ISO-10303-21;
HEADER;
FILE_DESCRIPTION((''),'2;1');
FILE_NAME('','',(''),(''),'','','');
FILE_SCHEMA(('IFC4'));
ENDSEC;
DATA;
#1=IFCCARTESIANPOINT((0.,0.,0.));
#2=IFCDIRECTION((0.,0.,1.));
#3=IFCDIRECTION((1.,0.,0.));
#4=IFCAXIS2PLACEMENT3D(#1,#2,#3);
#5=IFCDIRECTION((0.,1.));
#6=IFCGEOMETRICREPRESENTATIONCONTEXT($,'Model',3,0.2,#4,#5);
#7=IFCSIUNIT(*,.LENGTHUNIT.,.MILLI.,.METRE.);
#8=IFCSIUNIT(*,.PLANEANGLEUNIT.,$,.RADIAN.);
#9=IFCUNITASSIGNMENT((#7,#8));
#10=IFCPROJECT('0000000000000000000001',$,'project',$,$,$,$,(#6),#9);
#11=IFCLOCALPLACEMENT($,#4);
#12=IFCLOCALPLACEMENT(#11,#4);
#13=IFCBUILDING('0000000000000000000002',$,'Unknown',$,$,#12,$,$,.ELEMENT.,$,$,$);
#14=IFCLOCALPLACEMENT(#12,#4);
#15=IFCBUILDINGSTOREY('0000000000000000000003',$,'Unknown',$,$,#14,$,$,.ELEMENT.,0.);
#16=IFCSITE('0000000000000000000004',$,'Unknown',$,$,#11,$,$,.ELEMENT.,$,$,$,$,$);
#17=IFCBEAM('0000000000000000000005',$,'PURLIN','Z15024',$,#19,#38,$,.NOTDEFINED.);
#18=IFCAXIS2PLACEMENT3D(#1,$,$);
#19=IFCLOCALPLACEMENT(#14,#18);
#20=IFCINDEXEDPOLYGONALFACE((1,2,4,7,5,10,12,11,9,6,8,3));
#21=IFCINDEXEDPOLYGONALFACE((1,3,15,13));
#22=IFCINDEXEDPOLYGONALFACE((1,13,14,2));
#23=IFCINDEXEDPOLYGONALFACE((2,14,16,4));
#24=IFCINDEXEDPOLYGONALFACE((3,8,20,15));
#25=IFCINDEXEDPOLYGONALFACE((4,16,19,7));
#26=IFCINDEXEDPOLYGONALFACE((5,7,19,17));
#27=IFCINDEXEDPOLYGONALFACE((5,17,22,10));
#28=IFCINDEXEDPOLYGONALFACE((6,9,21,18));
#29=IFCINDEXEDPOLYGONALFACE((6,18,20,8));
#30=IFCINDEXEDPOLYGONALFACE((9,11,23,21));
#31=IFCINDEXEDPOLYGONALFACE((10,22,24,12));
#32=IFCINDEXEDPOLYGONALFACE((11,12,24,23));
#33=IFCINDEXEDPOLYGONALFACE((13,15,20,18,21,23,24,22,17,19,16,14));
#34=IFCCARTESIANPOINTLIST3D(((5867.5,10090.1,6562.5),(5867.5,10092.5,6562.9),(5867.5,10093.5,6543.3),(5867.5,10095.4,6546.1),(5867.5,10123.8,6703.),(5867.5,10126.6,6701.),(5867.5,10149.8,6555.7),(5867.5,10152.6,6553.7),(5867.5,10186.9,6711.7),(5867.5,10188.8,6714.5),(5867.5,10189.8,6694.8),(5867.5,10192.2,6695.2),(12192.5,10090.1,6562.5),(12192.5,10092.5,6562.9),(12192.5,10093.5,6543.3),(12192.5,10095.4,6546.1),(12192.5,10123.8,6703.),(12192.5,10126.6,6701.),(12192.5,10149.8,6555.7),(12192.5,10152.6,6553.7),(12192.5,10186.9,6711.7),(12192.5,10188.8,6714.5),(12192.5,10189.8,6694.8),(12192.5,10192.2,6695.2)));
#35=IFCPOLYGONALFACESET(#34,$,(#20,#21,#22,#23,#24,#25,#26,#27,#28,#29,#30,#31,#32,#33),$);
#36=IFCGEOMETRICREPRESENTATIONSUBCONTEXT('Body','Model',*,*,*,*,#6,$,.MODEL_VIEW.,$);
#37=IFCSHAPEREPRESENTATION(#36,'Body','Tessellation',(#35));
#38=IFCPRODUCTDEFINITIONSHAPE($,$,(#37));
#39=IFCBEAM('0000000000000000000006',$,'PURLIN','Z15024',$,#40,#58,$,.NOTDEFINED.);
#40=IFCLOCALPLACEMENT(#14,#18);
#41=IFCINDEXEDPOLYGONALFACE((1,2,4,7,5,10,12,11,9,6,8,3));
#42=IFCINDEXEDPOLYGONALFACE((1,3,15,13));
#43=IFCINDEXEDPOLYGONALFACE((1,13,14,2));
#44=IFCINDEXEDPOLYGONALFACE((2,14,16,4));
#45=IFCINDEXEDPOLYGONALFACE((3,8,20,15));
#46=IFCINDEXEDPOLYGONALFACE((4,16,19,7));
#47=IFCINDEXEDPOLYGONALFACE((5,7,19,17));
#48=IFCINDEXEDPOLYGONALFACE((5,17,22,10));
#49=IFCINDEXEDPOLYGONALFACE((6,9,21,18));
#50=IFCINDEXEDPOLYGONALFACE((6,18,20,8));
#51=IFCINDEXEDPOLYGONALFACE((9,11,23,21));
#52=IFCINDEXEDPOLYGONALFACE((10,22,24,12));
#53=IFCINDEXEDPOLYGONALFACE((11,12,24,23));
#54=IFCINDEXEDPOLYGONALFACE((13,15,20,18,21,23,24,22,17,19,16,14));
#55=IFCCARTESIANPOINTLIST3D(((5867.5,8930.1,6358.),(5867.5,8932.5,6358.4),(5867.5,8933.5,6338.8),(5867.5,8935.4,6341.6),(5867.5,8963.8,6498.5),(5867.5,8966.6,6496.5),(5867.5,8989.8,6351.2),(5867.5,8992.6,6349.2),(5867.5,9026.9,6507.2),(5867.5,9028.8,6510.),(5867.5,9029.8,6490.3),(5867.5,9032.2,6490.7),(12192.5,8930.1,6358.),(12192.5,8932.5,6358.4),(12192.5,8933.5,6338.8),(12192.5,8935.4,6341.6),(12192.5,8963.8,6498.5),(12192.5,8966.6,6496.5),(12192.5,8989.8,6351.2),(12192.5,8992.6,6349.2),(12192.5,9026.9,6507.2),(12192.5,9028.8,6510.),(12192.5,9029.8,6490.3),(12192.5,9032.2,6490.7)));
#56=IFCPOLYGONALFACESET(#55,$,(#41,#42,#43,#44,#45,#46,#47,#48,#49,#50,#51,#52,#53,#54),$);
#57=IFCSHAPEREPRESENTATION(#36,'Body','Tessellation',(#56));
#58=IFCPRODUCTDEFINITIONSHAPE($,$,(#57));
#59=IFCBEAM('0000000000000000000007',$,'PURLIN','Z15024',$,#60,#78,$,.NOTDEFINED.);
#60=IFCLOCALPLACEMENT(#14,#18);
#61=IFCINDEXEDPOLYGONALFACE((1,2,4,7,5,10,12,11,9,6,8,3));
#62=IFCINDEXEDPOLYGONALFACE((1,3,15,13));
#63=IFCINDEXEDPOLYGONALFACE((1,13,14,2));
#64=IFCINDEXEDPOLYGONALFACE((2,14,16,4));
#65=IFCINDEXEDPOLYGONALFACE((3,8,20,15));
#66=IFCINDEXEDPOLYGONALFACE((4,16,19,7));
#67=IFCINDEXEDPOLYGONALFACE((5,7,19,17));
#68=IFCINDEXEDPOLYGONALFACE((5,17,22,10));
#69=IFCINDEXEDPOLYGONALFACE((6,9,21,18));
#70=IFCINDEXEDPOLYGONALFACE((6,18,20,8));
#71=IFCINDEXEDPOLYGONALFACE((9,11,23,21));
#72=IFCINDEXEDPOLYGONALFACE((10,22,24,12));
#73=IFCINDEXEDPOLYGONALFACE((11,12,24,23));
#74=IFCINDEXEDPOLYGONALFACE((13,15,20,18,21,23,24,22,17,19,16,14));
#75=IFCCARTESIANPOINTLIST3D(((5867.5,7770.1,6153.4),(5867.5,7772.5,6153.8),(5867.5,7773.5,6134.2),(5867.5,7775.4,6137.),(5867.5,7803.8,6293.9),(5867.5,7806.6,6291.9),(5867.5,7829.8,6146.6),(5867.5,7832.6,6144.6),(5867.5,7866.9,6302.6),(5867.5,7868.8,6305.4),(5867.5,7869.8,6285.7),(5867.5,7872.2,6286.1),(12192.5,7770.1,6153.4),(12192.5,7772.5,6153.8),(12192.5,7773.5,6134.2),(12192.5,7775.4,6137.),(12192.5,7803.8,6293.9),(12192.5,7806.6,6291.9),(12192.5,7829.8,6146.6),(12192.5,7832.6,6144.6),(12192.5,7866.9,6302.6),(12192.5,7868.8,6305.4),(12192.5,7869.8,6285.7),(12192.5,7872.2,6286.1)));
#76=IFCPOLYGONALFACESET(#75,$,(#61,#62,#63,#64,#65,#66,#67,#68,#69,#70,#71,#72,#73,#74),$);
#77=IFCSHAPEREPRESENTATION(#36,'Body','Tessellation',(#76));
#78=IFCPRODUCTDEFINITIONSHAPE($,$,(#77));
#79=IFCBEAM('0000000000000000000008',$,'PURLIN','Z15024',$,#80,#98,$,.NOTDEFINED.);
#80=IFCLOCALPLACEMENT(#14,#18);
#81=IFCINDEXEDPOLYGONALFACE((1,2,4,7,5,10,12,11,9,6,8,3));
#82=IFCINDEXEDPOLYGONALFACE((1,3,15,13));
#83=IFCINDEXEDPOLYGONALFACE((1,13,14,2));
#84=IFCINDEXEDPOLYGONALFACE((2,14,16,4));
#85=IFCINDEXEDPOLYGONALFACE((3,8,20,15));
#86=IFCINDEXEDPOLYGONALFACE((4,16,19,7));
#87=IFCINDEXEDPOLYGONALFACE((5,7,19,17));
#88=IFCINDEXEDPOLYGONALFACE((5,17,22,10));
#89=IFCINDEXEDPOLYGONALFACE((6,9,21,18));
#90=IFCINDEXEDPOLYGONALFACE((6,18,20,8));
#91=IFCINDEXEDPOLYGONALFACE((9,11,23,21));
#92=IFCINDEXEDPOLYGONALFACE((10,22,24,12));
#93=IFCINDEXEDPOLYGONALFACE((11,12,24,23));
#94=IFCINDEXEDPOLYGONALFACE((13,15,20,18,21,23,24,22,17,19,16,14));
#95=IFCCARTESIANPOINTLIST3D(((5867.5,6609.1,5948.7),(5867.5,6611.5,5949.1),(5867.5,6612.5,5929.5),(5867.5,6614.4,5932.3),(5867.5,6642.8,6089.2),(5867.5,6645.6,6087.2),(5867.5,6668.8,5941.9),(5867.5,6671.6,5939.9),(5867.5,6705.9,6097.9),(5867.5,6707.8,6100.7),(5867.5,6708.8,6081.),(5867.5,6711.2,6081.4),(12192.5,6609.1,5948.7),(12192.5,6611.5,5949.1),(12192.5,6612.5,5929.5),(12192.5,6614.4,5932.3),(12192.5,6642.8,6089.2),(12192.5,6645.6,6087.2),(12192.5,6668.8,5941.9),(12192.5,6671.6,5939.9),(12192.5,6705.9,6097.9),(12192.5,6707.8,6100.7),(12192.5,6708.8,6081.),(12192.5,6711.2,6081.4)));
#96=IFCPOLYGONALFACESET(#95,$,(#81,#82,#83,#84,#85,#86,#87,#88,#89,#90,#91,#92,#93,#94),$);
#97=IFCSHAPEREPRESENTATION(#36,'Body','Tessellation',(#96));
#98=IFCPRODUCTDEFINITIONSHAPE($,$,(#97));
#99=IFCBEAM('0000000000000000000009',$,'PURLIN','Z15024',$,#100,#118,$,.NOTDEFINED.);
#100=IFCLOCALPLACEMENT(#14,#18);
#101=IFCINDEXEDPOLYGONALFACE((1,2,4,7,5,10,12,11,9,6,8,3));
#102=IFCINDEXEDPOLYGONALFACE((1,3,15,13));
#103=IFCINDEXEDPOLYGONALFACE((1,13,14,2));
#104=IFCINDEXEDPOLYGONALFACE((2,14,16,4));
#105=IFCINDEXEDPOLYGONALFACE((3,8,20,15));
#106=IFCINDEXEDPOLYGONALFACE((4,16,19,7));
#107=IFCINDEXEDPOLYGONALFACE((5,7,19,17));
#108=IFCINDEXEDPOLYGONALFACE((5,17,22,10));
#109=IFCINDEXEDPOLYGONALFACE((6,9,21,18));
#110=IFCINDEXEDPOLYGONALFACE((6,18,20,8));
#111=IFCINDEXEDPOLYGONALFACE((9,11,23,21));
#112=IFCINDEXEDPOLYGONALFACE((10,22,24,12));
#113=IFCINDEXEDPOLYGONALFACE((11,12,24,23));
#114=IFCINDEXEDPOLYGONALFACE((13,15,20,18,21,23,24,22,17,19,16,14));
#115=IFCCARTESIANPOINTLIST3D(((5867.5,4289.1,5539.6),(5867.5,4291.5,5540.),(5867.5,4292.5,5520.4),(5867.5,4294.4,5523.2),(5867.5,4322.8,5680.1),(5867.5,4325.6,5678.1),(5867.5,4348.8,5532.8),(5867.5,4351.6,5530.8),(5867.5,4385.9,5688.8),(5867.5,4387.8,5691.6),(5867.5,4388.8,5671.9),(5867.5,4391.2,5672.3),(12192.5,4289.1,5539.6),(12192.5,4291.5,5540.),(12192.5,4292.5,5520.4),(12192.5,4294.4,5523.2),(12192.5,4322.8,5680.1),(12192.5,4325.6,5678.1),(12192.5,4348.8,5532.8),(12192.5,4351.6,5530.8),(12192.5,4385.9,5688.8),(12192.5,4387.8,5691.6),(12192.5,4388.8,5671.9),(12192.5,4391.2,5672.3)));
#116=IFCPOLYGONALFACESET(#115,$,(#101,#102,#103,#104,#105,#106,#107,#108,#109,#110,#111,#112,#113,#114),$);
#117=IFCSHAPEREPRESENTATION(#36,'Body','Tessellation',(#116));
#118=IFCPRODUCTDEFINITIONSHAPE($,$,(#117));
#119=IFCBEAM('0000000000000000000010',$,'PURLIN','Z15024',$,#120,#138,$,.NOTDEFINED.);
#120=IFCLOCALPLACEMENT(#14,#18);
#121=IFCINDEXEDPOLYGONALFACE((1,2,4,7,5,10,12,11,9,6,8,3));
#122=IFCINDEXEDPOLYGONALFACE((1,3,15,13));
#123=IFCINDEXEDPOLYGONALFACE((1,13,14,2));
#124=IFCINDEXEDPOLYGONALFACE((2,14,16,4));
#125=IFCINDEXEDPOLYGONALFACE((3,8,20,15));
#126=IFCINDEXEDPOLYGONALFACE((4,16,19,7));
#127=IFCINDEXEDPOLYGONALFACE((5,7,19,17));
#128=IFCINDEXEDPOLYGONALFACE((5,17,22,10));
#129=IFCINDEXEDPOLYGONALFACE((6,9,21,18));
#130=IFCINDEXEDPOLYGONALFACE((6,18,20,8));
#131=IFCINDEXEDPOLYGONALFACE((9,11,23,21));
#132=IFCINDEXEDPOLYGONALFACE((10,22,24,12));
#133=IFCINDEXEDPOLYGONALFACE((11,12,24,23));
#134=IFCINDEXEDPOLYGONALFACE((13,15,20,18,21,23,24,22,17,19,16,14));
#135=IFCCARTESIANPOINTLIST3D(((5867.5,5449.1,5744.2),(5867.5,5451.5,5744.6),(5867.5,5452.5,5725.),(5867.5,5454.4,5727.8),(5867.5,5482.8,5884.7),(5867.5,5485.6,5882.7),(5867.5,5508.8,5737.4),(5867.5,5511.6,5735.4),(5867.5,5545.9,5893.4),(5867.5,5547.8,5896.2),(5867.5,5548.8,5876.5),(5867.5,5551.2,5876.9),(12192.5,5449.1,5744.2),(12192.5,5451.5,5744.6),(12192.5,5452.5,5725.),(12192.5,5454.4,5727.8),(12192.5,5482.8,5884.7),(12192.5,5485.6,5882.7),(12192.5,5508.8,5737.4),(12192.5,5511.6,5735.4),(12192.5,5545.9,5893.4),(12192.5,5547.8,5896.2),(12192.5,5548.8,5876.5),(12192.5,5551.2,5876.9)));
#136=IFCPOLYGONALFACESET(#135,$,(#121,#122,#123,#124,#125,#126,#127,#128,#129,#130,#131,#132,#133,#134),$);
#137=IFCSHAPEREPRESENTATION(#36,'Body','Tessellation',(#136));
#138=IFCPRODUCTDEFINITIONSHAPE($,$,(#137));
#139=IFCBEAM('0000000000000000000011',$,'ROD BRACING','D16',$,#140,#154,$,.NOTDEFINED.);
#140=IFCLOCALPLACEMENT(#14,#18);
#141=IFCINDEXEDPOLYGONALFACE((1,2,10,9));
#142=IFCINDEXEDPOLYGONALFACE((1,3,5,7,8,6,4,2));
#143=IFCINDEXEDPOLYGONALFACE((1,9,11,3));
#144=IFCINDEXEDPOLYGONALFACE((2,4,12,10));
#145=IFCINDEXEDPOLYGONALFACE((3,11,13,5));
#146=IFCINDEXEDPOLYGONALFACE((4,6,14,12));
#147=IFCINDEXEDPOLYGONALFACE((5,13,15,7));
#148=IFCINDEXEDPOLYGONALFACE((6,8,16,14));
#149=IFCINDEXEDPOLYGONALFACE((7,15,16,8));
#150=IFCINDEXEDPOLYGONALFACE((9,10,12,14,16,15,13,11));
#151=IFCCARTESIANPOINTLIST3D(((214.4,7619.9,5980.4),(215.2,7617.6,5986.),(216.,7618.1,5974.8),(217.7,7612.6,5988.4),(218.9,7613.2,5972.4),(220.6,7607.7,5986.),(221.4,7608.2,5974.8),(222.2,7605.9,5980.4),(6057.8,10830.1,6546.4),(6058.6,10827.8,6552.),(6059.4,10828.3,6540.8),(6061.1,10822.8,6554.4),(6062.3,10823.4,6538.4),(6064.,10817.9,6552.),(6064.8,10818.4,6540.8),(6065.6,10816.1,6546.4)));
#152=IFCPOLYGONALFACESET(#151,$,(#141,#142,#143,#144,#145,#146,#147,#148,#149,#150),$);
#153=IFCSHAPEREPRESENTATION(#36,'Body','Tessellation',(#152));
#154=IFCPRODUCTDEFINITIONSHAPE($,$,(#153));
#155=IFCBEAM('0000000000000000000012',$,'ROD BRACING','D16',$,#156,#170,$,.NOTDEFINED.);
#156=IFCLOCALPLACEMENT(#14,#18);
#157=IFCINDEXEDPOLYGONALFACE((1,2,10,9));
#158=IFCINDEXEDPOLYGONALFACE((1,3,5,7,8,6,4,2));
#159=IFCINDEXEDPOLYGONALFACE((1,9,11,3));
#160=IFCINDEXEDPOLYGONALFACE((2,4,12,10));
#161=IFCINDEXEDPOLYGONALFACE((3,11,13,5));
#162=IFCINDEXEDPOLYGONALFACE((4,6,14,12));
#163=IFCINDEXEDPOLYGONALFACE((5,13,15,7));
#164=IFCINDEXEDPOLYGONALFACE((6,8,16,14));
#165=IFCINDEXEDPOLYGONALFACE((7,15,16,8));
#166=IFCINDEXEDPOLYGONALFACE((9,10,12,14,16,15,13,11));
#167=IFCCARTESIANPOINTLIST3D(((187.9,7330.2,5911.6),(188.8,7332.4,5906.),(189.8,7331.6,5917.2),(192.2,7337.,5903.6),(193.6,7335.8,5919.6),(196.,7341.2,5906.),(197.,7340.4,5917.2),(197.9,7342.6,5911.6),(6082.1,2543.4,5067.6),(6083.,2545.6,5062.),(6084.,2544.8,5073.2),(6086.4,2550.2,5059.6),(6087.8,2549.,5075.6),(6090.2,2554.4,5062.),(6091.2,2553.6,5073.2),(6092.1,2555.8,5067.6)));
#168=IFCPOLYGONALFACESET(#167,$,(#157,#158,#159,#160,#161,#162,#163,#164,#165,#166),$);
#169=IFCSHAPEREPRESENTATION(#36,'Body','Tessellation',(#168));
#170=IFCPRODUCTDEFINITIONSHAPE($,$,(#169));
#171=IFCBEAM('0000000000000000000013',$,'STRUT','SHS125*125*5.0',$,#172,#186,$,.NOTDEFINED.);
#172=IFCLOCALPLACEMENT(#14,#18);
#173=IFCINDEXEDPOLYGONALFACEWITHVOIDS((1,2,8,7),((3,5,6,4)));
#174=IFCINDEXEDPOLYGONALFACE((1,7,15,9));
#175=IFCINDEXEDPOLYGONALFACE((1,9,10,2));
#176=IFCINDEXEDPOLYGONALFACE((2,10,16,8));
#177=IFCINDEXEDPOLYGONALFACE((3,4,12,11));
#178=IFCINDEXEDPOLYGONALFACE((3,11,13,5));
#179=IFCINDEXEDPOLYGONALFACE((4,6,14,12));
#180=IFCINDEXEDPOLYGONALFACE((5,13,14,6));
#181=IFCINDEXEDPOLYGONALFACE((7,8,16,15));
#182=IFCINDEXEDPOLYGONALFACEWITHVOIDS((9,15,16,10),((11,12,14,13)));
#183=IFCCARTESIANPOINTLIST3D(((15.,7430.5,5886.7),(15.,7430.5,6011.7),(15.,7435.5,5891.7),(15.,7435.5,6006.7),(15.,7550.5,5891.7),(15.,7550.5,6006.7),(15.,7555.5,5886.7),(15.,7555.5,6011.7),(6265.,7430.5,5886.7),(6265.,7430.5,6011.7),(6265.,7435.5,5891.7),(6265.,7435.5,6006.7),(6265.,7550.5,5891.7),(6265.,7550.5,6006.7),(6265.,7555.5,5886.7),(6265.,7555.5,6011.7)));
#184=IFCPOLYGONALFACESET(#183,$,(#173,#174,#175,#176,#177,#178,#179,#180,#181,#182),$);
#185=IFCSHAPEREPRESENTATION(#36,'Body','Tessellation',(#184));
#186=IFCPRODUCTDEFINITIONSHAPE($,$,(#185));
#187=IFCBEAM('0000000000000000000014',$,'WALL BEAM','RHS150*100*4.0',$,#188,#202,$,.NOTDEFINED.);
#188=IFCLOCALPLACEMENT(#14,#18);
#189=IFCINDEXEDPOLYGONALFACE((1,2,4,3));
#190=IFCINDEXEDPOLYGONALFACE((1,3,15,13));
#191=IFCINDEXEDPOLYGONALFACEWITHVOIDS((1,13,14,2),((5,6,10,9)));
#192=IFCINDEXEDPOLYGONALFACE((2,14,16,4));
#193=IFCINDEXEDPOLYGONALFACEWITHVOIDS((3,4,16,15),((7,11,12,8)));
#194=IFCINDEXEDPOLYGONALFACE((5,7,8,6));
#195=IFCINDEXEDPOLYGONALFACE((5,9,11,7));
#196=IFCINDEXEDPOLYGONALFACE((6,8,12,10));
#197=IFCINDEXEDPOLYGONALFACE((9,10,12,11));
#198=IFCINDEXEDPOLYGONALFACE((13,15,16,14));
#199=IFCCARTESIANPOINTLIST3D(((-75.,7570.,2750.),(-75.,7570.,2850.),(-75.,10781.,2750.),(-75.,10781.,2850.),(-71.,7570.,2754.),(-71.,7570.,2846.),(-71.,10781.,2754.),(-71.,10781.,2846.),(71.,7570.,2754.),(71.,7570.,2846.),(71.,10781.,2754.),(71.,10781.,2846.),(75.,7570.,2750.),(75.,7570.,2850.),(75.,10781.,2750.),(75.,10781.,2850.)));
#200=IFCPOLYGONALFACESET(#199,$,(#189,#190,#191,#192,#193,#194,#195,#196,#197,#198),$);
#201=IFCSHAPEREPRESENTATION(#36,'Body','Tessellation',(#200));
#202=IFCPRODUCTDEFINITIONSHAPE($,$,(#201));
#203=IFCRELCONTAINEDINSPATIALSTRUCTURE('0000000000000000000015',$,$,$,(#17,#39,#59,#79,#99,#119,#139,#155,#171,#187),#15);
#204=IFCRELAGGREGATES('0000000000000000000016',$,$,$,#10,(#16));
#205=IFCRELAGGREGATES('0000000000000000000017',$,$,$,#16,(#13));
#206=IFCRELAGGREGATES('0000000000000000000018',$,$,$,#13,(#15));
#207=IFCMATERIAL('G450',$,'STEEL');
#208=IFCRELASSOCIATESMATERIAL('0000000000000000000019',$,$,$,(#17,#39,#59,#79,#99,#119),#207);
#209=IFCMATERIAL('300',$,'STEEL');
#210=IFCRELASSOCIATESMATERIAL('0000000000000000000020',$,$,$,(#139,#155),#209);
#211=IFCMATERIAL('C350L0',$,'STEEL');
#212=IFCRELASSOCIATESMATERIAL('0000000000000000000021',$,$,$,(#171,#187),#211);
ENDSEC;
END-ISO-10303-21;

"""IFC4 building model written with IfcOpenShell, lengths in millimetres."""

from ifc_helpers import new_model, si_unit, direction, frame, origin_with_axes, place, context, subcontext, project, spatial, line, indexed_curve, outline, extrude, material, element, save


model = new_model("IFC4")

# Units and contexts
model_context = context("Model", 3, precision=0.2, world=origin_with_axes(), true_north=direction((0.0, 1.0)))
body_context = subcontext(model_context, "Body", "Model", "MODEL_VIEW")
ifc_project = project(units=[si_unit("LENGTHUNIT", "METRE", prefix="MILLI"), si_unit("PLANEANGLEUNIT", "RADIAN")], contexts=[model_context])

# Site, building, storey
site_placement = place(None, origin_with_axes())
site = spatial("IfcSite", under=ifc_project, at=site_placement, Name="Unknown", CompositionType="ELEMENT")
building_placement = place(site_placement, origin_with_axes())
building = spatial("IfcBuilding", under=site, at=building_placement, Name="Unknown", CompositionType="ELEMENT")
storey_placement = place(building_placement, origin_with_axes())
storey = spatial("IfcBuildingStorey", under=building, at=storey_placement, Name="Unknown", CompositionType="ELEMENT", Elevation=0.0)

# Beams
ifc_material_1 = material(Name="G450", Category="STEEL")
for number, where, z_axis, x_axis, name in (
    (1, (5867.5, 10138.2, 6628.4), (0.0, -0.984808, -0.173648), (1.0, 0.0, 0.0), "PURLIN"),
    (2, (5867.5, 8978.2, 6423.9), (0.0, -0.984808, -0.173648), (1.0, 0.0, 0.0), "PURLIN"),
    (3, (5867.5, 7818.2, 6219.3), (0.0, -0.984808, -0.173648), (1.0, 0.0, 0.0), "PURLIN"),
    (4, (5867.5, 6657.2, 6014.6), (0.0, -0.984808, -0.173648), (1.0, 0.0, 0.0), "PURLIN"),
    (5, (5867.5, 4337.2, 5605.5), (0.0, -0.984808, -0.173648), (1.0, 0.0, 0.0), "PURLIN"),
    (6, (5867.5, 5497.2, 5810.1), (0.0, -0.984808, -0.173648), (1.0, 0.0, 0.0), "PURLIN"),
):
    element("IfcBeam", number, at=place(storey_placement, frame(where, z_axis=z_axis, x_axis=x_axis)), inside=storey, material=ifc_material_1, Name=name, Description="Z15024", PredefinedType="NOTDEFINED", context=body_context, shape_type="SolidModel", body=[
        extrude(outline(indexed_curve([(58.8, -76.0), (58.8, -56.5), (56.4, -56.5), (56.4, -73.6), (1.2, -73.6), (1.2, 76.0), (-64.8, 76.0), (-64.8, 56.5), (-62.4, 56.5), (-62.4, 73.6), (-1.2, 73.6), (-1.2, -76.0)], segments=[line(1, 2, 3, 4, 5, 6, 7, 8, 9, 10, 11, 12, 1)])), frame((0.0, 0.0, 0.0), z_axis=(-1.0, 0.0, 0.0), x_axis=(0.0, 0.0, 1.0)), (0.0, 0.0, -1.0), 6325.0),
    ])
ifc_material_2 = material(Name="300", Category="STEEL")
beam_1_placement = place(storey_placement, frame((218.3, 7612.9, 5980.4), z_axis=(-0.074139, -0.04073, 0.996416), x_axis=(0.873307, 0.47977, 0.08459)))
element("IfcBeam", 7, at=beam_1_placement, inside=storey, material=ifc_material_2, Name="ROD BRACING", Description="D16", PredefinedType="NOTDEFINED", context=body_context, shape_type="SolidModel", body=[
    extrude(outline(indexed_curve([(8.0, 0.0), (5.7, 5.7), (0.0, 8.0), (-5.7, 5.7), (-8.0, 0.0), (-5.7, -5.7), (0.0, -8.0), (5.7, -5.7)], segments=[line(1, 2, 3, 4, 5, 6, 7, 8, 1)])), frame((0.0, 0.0, 0.0), z_axis=(-1.0, 0.0, 0.0), x_axis=(0.0, 0.0, 1.0)), (0.0, 0.0, -1.0), 6691.1),
])
beam_2_placement = place(storey_placement, frame((192.9, 7336.4, 5911.6), z_axis=(0.085756, -0.069644, 0.993879), x_axis=(0.771507, -0.626556, -0.110473)))
element("IfcBeam", 8, at=beam_2_placement, inside=storey, material=ifc_material_2, Name="ROD BRACING", Description="D16", PredefinedType="NOTDEFINED", context=body_context, shape_type="SolidModel", body=[
    extrude(outline(indexed_curve([(8.0, 0.0), (5.7, 5.7), (0.0, 8.0), (-5.7, 5.7), (-8.0, 0.0), (-5.7, -5.7), (0.0, -8.0), (5.7, -5.7)], segments=[line(1, 2, 3, 4, 5, 6, 7, 8, 1)])), frame((0.0, 0.0, 0.0), z_axis=(-1.0, 0.0, 0.0), x_axis=(0.0, 0.0, 1.0)), (0.0, 0.0, -1.0), 7639.9),
])
ifc_material_3 = material(Name="C350L0", Category="STEEL")
beam_3_placement = place(storey_placement, frame((15.0, 7493.0, 5949.2), z_axis=(0.0, 0.0, 1.0), x_axis=(1.0, 0.0, 0.0)))
element("IfcBeam", 9, at=beam_3_placement, inside=storey, material=ifc_material_3, Name="STRUT", Description="SHS125*125*5.0", PredefinedType="NOTDEFINED", context=body_context, shape_type="SolidModel", body=[
    extrude(outline(indexed_curve([(-62.5, -62.5), (62.5, -62.5), (62.5, 62.5), (-62.5, 62.5)], segments=[line(1, 2, 3, 4, 1)]), holes=[indexed_curve([(-57.5, -57.5), (-57.5, 57.5), (57.5, 57.5), (57.5, -57.5)], segments=[line(1, 2, 3, 4, 1)])]), frame((0.0, 0.0, 0.0), z_axis=(-1.0, 0.0, 0.0), x_axis=(0.0, 0.0, 1.0)), (0.0, 0.0, -1.0), 6250.0),
])
beam_4_placement = place(storey_placement, frame((0.0, 7570.0, 2800.0), z_axis=(0.0, 0.0, 1.0), x_axis=(0.0, 1.0, 0.0)))
element("IfcBeam", 10, at=beam_4_placement, inside=storey, material=ifc_material_3, Name="WALL BEAM", Description="RHS150*100*4.0", PredefinedType="NOTDEFINED", context=body_context, shape_type="SolidModel", body=[
    extrude(outline(indexed_curve([(-50.0, -75.0), (50.0, -75.0), (50.0, 75.0), (-50.0, 75.0)], segments=[line(1, 2, 3, 4, 1)]), holes=[indexed_curve([(-46.0, -71.0), (-46.0, 71.0), (46.0, 71.0), (46.0, -71.0)], segments=[line(1, 2, 3, 4, 1)])]), frame((0.0, 0.0, 0.0), z_axis=(-1.0, 0.0, 0.0), x_axis=(0.0, 0.0, 1.0)), (0.0, 0.0, -1.0), 3211.0),
])

save(model, "model.ifc")
